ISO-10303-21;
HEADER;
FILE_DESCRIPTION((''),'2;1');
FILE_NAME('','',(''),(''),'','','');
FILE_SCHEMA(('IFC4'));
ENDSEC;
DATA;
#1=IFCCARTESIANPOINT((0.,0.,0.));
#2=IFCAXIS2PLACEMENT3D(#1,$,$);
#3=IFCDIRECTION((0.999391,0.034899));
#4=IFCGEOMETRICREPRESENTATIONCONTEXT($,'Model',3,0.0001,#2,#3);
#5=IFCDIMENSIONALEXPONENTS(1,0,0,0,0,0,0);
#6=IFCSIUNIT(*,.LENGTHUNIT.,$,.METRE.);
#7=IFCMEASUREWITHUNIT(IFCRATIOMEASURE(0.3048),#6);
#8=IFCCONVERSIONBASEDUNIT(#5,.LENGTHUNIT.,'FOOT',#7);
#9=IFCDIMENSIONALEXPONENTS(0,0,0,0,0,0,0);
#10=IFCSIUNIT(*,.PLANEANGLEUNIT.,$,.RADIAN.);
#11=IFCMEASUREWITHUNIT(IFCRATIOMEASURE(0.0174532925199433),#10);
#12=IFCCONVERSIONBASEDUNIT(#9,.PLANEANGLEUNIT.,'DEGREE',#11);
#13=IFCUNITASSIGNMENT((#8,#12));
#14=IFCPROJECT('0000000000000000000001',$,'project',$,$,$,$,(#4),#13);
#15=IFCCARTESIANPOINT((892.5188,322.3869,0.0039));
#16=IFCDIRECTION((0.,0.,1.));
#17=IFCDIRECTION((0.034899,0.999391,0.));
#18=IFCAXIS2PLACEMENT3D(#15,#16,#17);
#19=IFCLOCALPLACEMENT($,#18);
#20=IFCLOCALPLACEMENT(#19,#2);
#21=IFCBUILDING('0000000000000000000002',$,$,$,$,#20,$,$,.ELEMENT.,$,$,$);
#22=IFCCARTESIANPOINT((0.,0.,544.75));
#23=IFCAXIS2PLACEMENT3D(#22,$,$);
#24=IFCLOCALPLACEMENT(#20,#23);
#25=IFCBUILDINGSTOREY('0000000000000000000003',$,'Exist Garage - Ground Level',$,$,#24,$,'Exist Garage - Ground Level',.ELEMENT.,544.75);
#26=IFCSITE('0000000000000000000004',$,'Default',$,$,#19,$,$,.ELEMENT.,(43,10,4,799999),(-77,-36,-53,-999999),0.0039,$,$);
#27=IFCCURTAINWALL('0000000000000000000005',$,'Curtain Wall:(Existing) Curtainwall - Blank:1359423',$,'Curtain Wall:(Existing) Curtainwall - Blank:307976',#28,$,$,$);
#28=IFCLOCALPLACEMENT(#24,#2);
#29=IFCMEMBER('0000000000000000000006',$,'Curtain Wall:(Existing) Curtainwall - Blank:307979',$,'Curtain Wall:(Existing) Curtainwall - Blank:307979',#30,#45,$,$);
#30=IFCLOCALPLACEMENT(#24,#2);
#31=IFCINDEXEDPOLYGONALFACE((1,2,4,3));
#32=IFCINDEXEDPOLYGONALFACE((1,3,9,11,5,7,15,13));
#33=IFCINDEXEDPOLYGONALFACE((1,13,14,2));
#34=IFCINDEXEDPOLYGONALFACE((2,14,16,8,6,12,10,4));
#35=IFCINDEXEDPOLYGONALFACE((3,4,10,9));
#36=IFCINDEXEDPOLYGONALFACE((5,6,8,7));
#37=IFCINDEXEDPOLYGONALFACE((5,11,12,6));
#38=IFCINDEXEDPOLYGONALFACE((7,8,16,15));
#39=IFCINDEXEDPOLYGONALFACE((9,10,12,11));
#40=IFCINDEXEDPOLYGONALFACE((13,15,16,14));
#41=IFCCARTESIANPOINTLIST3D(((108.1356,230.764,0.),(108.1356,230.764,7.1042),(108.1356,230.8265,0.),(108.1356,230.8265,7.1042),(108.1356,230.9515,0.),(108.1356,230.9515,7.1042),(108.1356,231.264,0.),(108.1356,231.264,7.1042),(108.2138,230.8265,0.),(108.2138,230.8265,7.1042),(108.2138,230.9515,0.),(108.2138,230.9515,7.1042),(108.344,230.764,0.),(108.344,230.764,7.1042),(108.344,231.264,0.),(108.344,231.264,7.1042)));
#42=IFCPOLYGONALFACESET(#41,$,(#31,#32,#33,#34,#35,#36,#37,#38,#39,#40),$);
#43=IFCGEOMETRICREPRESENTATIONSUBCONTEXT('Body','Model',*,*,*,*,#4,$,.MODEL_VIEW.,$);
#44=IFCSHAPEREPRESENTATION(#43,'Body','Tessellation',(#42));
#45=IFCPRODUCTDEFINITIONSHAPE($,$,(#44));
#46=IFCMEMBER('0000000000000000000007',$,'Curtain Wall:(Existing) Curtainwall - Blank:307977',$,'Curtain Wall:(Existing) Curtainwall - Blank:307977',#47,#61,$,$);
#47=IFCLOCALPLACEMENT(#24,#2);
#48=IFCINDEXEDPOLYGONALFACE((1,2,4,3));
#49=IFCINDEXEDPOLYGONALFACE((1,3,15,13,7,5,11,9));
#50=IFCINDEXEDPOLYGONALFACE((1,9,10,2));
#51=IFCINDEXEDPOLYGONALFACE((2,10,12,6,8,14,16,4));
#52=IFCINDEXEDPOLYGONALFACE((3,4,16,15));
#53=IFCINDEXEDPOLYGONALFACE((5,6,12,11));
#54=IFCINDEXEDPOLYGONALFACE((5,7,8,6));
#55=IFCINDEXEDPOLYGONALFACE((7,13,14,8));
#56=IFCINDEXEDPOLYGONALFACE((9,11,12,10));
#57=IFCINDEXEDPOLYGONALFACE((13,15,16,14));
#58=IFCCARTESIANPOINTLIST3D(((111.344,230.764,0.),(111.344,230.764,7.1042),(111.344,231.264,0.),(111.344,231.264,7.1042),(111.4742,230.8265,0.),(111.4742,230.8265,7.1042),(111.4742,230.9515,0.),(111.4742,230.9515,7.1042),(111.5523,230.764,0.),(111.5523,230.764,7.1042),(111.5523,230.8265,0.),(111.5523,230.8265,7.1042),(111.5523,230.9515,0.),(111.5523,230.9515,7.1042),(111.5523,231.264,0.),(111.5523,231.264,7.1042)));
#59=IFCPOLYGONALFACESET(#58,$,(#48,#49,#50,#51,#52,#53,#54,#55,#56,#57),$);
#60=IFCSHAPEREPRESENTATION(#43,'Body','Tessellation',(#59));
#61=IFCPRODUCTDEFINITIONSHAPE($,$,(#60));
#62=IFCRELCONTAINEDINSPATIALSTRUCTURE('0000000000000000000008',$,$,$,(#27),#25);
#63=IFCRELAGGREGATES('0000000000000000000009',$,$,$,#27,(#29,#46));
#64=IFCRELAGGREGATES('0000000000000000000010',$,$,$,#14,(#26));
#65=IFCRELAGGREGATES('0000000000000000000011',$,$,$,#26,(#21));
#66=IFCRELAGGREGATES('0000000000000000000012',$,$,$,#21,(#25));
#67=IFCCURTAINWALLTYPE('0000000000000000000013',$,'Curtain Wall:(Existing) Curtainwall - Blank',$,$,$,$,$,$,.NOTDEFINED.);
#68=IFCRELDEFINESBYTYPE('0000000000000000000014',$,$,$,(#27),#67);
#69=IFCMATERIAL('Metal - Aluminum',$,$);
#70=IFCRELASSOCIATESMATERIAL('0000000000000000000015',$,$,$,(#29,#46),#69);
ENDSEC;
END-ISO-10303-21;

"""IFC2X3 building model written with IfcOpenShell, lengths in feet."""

from ifc_helpers import new_model, entity, si_unit, converted_unit, direction, frame, origin, place, context, subcontext, project, spatial, polyline, outline, extrude, material, type_object, element, aggregate, save


model = new_model("IFC2X3")

# Units and contexts
model_context = context("Model", 3, precision=0.0001, world=origin(), true_north=direction((0.999391, 0.034899)))
body_context = subcontext(model_context, "Body", "Model", "MODEL_VIEW")
ifc_project = project(units=[converted_unit("LENGTHUNIT", "FOOT", entity("IfcRatioMeasure", 0.3048), si_unit("LENGTHUNIT", "METRE"), dimensions=[1, 0, 0, 0, 0, 0, 0]), converted_unit("PLANEANGLEUNIT", "DEGREE", entity("IfcRatioMeasure", 0.0174532925199433), si_unit("PLANEANGLEUNIT", "RADIAN"), dimensions=[0, 0, 0, 0, 0, 0, 0])], contexts=[model_context])

# Site, building, storey
site_placement = place(None, frame((892.5188, 322.3869, 0.0039), z_axis=(0.0, 0.0, 1.0), x_axis=(0.034899, 0.999391, 0.0)))
site = spatial("IfcSite", under=ifc_project, at=site_placement, Name="Default", CompositionType="ELEMENT", RefLatitude=(43, 10, 4, 799999), RefLongitude=(-77, -36, -53, -999999), RefElevation=0.0039)
building_placement = place(site_placement, origin())
building = spatial("IfcBuilding", under=site, at=building_placement, CompositionType="ELEMENT")
storey_placement = place(building_placement, frame((0.0, 0.0, 544.75)))
storey = spatial("IfcBuildingStorey", under=building, at=storey_placement, Name="Exist Garage - Ground Level", LongName="Exist Garage - Ground Level", CompositionType="ELEMENT", Elevation=544.75)

# Curtain wall, members
curtain_wall_type = type_object("IfcCurtainWallType", Name="Curtain Wall:(Existing) Curtainwall - Blank", PredefinedType="NOTDEFINED")
curtain_wall_placement = place(storey_placement, frame((0.0, 0.0, -544.75)))
curtain_wall = element("IfcCurtainWall", 1, at=curtain_wall_placement, inside=storey, type_object=curtain_wall_type, Name="Curtain Wall:(Existing) Curtainwall - Blank:1359423", ObjectType="Curtain Wall:(Existing) Curtainwall - Blank:307976")
ifc_material = material(Name="Metal - Aluminum")
member_1_placement = place(curtain_wall_placement, frame((0.0, 0.0, 544.75)))
member_1 = element("IfcMember", 2, at=member_1_placement, material=ifc_material, Name="Curtain Wall:(Existing) Curtainwall - Blank:307979", ObjectType="Curtain Wall:(Existing) Curtainwall - Blank:307979", context=body_context, shape_type="SweptSolid", body=[
    extrude(outline(polyline([(-0.1367, -0.3125), (0.0716, -0.3125), (0.0716, 0.0), (-0.0065, 0.0), (-0.0065, 0.125), (0.0716, 0.125), (0.0716, 0.1875), (-0.1367, 0.1875), (-0.1367, -0.3125)])), frame((108.2072, 230.9515, 0.0), z_axis=(0.0, 0.0, 1.0), x_axis=(-1.0, 0.0, 0.0)), (0.0, 0.0, 1.0), 7.1042),
])
member_2_placement = place(curtain_wall_placement, frame((0.0, 0.0, 544.75)))
member_2 = element("IfcMember", 3, at=member_2_placement, material=ifc_material, Name="Curtain Wall:(Existing) Curtainwall - Blank:307977", ObjectType="Curtain Wall:(Existing) Curtainwall - Blank:307977", context=body_context, shape_type="SweptSolid", body=[
    extrude(outline(polyline([(-0.0716, -0.3125), (0.1367, -0.3125), (0.1367, 0.1875), (-0.0716, 0.1875), (-0.0716, 0.125), (0.0065, 0.125), (0.0065, 0.0), (-0.0716, 0.0), (-0.0716, -0.3125)])), frame((111.4807, 230.9515, 0.0), z_axis=(0.0, 0.0, 1.0), x_axis=(-1.0, 0.0, 0.0)), (0.0, 0.0, 1.0), 7.1042),
])
aggregate(curtain_wall, [member_1, member_2])

save(model, "model.ifc")
